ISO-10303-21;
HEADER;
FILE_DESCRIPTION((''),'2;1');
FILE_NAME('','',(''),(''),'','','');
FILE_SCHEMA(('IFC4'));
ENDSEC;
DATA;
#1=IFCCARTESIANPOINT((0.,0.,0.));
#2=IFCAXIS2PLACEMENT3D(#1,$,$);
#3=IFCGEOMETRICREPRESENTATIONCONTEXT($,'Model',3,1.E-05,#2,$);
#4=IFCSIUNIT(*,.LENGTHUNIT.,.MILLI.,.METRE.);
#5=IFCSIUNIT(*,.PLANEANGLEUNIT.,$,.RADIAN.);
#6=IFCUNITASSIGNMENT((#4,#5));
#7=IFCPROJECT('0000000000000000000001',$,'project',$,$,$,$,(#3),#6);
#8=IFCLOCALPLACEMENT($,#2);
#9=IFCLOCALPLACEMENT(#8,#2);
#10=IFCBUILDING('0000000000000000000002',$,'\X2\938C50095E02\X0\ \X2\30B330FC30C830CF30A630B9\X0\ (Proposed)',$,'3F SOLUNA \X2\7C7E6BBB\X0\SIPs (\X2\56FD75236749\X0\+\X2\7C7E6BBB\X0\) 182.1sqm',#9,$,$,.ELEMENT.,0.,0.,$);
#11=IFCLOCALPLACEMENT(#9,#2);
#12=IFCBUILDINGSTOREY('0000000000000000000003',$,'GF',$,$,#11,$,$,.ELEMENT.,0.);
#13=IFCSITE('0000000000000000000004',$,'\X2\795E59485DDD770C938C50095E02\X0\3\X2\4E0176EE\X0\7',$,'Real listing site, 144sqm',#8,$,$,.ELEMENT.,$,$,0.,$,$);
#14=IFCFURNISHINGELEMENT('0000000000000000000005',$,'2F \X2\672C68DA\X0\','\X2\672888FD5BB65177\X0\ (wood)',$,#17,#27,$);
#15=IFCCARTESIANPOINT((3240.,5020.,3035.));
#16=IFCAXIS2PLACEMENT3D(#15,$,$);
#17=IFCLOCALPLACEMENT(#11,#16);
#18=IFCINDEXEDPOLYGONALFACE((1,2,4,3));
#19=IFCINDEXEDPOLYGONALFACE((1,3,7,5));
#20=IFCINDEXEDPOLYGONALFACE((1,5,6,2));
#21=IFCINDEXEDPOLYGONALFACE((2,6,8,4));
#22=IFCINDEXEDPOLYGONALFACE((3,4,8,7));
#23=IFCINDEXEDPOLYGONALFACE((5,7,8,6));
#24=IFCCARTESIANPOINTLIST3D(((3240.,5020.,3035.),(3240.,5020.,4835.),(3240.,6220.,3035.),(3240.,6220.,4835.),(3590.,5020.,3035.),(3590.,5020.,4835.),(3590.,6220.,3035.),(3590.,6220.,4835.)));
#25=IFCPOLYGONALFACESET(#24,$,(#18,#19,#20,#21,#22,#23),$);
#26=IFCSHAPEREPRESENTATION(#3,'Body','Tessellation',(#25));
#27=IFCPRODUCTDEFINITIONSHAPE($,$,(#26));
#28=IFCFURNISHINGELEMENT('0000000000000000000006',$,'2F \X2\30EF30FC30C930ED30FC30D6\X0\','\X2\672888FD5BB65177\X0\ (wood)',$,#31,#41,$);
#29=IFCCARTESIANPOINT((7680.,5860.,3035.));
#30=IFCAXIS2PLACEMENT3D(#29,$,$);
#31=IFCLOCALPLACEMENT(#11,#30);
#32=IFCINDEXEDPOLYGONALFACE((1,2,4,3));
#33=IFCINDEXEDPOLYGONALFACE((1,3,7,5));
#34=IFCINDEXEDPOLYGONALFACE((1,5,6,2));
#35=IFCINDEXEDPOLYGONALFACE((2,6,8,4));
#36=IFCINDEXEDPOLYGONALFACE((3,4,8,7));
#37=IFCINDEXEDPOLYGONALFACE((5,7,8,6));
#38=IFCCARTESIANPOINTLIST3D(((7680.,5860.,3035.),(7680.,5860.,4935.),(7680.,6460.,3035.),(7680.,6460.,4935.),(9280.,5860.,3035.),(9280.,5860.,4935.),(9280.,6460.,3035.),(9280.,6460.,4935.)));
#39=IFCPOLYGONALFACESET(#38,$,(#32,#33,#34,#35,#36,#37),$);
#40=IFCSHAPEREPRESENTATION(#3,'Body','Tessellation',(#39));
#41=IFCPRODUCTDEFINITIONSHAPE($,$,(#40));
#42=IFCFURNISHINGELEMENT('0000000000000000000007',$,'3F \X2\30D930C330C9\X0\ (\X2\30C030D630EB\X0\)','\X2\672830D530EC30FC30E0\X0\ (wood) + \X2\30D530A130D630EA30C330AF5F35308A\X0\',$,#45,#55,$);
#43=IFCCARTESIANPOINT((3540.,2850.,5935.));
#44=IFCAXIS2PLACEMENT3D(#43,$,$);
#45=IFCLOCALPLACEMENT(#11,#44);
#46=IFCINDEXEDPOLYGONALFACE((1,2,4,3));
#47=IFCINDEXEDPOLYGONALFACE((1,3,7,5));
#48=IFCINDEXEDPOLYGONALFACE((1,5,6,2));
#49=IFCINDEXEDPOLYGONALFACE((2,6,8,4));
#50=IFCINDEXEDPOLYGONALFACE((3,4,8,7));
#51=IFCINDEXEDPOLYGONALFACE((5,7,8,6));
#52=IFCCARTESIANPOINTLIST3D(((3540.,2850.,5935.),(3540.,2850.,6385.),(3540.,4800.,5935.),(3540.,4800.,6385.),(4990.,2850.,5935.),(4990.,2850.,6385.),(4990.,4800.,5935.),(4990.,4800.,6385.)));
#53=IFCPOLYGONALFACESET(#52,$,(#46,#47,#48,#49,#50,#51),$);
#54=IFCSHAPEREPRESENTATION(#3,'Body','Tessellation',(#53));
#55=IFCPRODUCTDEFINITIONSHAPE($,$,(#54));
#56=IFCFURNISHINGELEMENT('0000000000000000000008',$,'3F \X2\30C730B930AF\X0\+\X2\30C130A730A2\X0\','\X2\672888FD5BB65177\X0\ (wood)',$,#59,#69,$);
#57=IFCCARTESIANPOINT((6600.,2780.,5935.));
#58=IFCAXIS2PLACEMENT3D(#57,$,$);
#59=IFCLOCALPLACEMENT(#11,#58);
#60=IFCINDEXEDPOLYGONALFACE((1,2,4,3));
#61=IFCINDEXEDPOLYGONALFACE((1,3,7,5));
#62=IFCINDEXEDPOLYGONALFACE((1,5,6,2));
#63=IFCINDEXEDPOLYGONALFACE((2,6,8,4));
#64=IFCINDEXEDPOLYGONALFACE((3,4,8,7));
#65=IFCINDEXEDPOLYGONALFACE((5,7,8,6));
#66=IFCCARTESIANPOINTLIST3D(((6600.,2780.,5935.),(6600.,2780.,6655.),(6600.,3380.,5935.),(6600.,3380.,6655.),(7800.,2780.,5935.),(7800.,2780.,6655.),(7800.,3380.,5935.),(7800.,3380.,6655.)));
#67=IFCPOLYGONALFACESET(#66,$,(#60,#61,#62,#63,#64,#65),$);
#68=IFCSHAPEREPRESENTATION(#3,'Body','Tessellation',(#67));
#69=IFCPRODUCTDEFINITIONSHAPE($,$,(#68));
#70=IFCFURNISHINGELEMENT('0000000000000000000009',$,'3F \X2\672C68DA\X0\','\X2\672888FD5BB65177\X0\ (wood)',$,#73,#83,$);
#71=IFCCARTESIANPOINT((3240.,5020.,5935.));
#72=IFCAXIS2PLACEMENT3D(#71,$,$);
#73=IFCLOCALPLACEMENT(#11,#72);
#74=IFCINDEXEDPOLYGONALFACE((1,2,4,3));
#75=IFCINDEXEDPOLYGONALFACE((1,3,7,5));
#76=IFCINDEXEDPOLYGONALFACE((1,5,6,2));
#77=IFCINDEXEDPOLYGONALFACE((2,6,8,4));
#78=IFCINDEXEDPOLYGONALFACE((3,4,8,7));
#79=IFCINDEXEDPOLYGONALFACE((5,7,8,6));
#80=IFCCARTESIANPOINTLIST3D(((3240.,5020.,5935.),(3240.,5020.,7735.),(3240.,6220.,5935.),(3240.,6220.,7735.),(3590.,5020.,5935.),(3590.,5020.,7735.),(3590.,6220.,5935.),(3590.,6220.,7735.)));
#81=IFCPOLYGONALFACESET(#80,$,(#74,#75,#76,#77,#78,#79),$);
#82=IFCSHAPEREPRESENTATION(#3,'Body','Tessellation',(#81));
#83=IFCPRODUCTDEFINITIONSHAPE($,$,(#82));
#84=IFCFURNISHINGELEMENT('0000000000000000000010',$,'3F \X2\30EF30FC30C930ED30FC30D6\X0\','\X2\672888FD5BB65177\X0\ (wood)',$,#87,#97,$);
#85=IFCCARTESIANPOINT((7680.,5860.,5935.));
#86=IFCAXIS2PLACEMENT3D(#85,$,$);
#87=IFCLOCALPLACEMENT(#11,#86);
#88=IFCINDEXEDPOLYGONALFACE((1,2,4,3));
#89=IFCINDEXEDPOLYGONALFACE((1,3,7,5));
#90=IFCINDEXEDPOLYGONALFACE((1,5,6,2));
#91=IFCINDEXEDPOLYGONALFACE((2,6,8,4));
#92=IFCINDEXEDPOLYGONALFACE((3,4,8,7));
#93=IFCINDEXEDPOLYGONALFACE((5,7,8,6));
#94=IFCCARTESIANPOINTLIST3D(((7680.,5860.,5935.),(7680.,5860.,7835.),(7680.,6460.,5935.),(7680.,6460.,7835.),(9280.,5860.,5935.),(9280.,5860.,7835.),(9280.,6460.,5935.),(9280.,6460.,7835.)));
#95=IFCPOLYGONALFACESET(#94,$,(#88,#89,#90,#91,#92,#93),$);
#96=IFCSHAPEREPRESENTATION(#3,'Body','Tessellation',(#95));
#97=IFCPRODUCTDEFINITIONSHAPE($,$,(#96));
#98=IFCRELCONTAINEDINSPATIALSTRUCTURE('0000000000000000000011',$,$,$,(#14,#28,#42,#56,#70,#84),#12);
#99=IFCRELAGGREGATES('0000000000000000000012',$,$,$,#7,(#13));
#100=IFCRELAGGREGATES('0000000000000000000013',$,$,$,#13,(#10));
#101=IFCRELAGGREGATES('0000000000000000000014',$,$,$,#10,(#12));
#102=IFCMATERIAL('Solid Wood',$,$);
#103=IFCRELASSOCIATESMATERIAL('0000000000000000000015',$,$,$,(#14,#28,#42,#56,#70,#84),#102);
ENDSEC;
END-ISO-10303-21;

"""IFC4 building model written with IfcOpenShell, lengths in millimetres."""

from ifc_helpers import new_model, si_unit, frame, frame_2d, origin, place, context, project, spatial, rectangle, extrude, material, element, save


model = new_model("IFC4")

# Units and contexts
model_context = context("Model", 3, precision=1e-05, world=origin())
ifc_project = project(units=[si_unit("LENGTHUNIT", "METRE", prefix="MILLI"), si_unit("PLANEANGLEUNIT", "RADIAN")], contexts=[model_context])

# Site, building, storey
site_placement = place(None, origin())
site = spatial("IfcSite", under=ifc_project, at=site_placement, Name="神奈川県鎌倉市3丁目7", ObjectType="Real listing site, 144sqm", CompositionType="ELEMENT", RefElevation=0.0)
building_placement = place(site_placement, origin())
building = spatial("IfcBuilding", under=site, at=building_placement, Name="鎌倉市 コートハウス (Proposed)", ObjectType="3F SOLUNA 籾殻SIPs (国産杉+籾殻) 182.1sqm", CompositionType="ELEMENT", ElevationOfRefHeight=0.0, ElevationOfTerrain=0.0)
storey_placement = place(building_placement, origin())
storey = spatial("IfcBuildingStorey", under=building, at=storey_placement, Name="GF", CompositionType="ELEMENT", Elevation=0.0)

# Shared definitions
ifc_material_1 = material(Name="Solid Wood")

# Furnishing elements
furnishing_1_placement = place(storey_placement, frame((3240.0, 5020.0, 3035.0)))
element("IfcFurnishingElement", 1, at=furnishing_1_placement, inside=storey, material=ifc_material_1, Name="2F 本棚", Description="木製家具 (wood)", context=model_context, shape_type="SweptSolid", body=[
    extrude(rectangle(XDim=350.0, YDim=1200.0, at=frame_2d((175.0, 600.0))), frame((3240.0, 5020.0, 3035.0)), (0.0, 0.0, 1.0), 1800.0),
])
furnishing_2_placement = place(storey_placement, frame((7680.0, 5860.0, 3035.0)))
element("IfcFurnishingElement", 2, at=furnishing_2_placement, inside=storey, material=ifc_material_1, Name="2F ワードローブ", Description="木製家具 (wood)", context=model_context, shape_type="SweptSolid", body=[
    extrude(rectangle(XDim=1600.0, YDim=600.0, at=frame_2d((800.0, 300.0))), frame((7680.0, 5860.0, 3035.0)), (0.0, 0.0, 1.0), 1900.0),
])
furnishing_3_placement = place(storey_placement, frame((3540.0, 2850.0, 5935.0)))
element("IfcFurnishingElement", 3, at=furnishing_3_placement, inside=storey, material=ifc_material_1, Name="3F ベッド (ダブル)", Description="木フレーム (wood) + ファブリック張り", context=model_context, shape_type="SweptSolid", body=[
    extrude(rectangle(XDim=1450.0, YDim=1950.0, at=frame_2d((725.0, 975.0))), frame((3540.0, 2850.0, 5935.0)), (0.0, 0.0, 1.0), 450.0),
])
furnishing_4_placement = place(storey_placement, frame((6600.0, 2780.0, 5935.0)))
element("IfcFurnishingElement", 4, at=furnishing_4_placement, inside=storey, material=ifc_material_1, Name="3F デスク+チェア", Description="木製家具 (wood)", context=model_context, shape_type="SweptSolid", body=[
    extrude(rectangle(XDim=1200.0, YDim=600.0, at=frame_2d((600.0, 300.0))), frame((6600.0, 2780.0, 5935.0)), (0.0, 0.0, 1.0), 720.0),
])
furnishing_5_placement = place(storey_placement, frame((3240.0, 5020.0, 5935.0)))
element("IfcFurnishingElement", 5, at=furnishing_5_placement, inside=storey, material=ifc_material_1, Name="3F 本棚", Description="木製家具 (wood)", context=model_context, shape_type="SweptSolid", body=[
    extrude(rectangle(XDim=350.0, YDim=1200.0, at=frame_2d((175.0, 600.0))), frame((3240.0, 5020.0, 5935.0)), (0.0, 0.0, 1.0), 1800.0),
])
furnishing_6_placement = place(storey_placement, frame((7680.0, 5860.0, 5935.0)))
element("IfcFurnishingElement", 6, at=furnishing_6_placement, inside=storey, material=ifc_material_1, Name="3F ワードローブ", Description="木製家具 (wood)", context=model_context, shape_type="SweptSolid", body=[
    extrude(rectangle(XDim=1600.0, YDim=600.0, at=frame_2d((800.0, 300.0))), frame((7680.0, 5860.0, 5935.0)), (0.0, 0.0, 1.0), 1900.0),
])

save(model, "model.ifc")
